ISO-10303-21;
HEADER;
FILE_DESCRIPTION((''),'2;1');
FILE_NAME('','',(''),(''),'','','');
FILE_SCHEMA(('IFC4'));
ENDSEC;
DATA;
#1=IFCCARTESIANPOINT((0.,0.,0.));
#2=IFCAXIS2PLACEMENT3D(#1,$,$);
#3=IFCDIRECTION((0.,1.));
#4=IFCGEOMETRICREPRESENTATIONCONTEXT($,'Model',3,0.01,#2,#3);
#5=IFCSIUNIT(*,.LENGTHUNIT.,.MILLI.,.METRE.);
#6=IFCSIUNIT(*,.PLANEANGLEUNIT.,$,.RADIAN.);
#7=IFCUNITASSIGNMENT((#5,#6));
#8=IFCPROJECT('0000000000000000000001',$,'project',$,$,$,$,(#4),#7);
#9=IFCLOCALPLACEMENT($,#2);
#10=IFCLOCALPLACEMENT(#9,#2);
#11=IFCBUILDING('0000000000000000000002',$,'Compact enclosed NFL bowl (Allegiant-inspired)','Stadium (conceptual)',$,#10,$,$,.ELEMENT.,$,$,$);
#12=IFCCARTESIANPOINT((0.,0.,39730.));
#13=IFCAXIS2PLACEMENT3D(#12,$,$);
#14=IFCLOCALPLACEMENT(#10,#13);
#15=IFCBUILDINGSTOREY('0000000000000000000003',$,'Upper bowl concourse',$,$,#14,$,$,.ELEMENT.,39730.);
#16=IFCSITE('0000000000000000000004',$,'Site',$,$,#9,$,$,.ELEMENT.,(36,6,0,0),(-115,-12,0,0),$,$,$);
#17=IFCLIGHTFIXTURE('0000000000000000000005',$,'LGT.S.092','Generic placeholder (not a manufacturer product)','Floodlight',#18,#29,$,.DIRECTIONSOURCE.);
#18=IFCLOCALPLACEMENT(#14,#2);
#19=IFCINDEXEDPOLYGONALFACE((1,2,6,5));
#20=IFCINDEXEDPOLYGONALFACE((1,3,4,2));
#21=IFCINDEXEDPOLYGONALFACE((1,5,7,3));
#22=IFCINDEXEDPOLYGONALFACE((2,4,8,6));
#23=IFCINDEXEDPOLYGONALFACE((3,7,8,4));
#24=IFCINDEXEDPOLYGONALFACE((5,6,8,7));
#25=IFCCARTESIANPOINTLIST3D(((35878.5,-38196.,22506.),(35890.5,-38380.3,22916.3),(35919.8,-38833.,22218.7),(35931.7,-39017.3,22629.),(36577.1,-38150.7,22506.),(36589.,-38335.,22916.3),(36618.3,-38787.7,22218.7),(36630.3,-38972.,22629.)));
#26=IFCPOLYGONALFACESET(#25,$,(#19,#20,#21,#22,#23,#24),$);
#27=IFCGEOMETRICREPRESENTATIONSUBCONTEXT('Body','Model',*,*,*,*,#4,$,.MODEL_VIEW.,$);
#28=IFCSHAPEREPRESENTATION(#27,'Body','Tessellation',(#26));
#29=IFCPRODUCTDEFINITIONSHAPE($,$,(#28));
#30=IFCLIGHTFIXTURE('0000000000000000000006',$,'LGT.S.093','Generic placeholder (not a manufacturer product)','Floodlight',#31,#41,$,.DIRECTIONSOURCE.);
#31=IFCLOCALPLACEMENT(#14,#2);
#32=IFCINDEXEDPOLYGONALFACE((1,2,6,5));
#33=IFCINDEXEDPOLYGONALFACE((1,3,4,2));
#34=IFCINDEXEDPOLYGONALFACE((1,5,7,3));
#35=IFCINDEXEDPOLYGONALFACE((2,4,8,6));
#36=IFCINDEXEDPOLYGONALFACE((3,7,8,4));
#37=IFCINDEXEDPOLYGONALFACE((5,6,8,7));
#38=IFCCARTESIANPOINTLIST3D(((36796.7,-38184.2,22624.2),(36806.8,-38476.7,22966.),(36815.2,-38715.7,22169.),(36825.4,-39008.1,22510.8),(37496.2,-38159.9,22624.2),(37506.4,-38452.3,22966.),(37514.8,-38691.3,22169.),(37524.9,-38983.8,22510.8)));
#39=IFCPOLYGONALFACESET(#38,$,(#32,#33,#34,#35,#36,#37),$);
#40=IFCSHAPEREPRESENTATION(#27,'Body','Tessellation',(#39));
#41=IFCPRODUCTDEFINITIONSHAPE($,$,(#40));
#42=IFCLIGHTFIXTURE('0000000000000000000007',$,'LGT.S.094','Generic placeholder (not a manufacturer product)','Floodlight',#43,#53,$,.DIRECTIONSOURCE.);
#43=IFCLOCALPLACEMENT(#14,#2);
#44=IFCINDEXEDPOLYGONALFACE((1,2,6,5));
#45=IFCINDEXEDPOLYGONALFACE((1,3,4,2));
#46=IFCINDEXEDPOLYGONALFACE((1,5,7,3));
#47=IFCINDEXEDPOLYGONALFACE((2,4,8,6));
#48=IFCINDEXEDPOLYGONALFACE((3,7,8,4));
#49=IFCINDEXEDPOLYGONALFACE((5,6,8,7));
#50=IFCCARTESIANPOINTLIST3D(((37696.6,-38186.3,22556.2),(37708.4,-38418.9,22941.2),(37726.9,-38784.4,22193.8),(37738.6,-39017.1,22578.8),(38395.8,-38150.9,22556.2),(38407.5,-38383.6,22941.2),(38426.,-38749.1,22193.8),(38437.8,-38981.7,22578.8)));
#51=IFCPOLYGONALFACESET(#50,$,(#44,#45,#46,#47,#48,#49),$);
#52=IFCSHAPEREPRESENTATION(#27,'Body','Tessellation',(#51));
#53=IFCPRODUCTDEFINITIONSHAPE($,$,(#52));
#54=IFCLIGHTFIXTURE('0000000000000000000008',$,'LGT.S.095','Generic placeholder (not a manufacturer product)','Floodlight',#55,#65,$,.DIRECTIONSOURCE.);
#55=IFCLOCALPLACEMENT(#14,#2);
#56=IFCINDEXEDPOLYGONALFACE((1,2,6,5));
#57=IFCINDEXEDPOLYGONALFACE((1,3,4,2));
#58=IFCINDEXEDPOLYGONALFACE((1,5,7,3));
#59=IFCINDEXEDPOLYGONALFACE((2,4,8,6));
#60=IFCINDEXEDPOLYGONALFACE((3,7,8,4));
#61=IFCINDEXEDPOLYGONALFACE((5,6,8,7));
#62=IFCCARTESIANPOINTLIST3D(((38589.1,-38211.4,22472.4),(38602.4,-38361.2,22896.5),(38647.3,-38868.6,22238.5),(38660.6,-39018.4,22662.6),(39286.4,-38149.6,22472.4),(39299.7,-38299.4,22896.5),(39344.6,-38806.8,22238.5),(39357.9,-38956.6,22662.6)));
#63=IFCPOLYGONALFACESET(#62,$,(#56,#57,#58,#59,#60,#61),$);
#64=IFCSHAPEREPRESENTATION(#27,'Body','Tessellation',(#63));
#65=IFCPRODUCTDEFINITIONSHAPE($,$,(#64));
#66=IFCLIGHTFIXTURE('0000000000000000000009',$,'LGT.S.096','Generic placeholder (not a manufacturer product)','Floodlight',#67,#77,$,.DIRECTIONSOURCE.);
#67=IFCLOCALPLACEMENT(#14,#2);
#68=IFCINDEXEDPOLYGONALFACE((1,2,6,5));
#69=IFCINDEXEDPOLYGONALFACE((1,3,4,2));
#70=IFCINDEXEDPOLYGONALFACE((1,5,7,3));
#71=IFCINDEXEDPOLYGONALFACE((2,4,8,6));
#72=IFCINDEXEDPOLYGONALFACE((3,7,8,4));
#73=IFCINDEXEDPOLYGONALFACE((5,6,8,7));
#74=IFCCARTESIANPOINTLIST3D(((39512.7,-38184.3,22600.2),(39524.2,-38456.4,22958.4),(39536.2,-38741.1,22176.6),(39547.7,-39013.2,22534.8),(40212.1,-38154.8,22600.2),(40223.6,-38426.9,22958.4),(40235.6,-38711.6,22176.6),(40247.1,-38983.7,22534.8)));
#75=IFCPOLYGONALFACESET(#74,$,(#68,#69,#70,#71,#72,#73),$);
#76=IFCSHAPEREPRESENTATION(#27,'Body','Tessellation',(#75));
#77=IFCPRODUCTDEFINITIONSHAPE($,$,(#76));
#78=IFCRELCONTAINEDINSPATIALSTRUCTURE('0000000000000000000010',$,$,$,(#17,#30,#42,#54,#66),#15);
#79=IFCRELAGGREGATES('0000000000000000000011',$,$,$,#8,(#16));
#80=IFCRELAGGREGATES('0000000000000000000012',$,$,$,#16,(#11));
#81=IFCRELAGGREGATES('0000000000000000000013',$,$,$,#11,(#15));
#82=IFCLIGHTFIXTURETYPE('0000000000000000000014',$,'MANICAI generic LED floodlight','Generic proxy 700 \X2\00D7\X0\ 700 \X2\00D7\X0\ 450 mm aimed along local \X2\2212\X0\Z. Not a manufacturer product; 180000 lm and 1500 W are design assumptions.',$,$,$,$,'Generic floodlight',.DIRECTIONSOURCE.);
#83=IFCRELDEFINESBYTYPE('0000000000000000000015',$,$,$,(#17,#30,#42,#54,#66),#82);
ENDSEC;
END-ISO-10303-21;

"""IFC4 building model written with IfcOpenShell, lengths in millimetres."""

from ifc_helpers import new_model, si_unit, direction, frame, origin, place, context, subcontext, project, spatial, rectangle, extrude, source, transform, mapped, type_object, type_shapes, element, save


model = new_model("IFC4")

# Units and contexts
model_context = context("Model", 3, precision=0.01, world=origin(), true_north=direction((0.0, 1.0)))
body_context = subcontext(model_context, "Body", "Model", "MODEL_VIEW")
ifc_project = project(units=[si_unit("LENGTHUNIT", "METRE", prefix="MILLI"), si_unit("PLANEANGLEUNIT", "RADIAN")], contexts=[model_context])

# Site, building, storey
site_placement = place(None, origin())
site = spatial("IfcSite", under=ifc_project, at=site_placement, Name="Site", CompositionType="ELEMENT", RefLatitude=(36, 6, 0, 0), RefLongitude=(-115, -12, 0, 0))
building_placement = place(site_placement, origin())
building = spatial("IfcBuilding", under=site, at=building_placement, Name="Compact enclosed NFL bowl (Allegiant-inspired)", Description="Stadium (conceptual)", CompositionType="ELEMENT")
storey_placement = place(building_placement, frame((0.0, 0.0, 39730.0)))
storey = spatial("IfcBuildingStorey", under=building, at=storey_placement, Name="Upper bowl concourse", CompositionType="ELEMENT", Elevation=39730.0)

# Light fixtures
light_fixture_type = type_object("IfcLightFixtureType", Name="MANICAI generic LED floodlight", Description="Generic proxy 700 × 700 × 450 mm aimed along local −Z. Not a manufacturer product; 180000 lm and 1500 W are design assumptions.", ElementType="Generic floodlight", PredefinedType="DIRECTIONSOURCE")
shared_shape = source(origin(), body_context, "Body", "SweptSolid", [
    extrude(rectangle(XDim=700.0, YDim=700.0), frame((0.0, 0.0, -225.0)), (0.0, 0.0, 1.0), 450.0),
])
type_shapes(light_fixture_type, [shared_shape])
for number, where, z_axis, x_axis, name in (
    (1, (36254.4, -38584.0, 22567.5), (0.026535, -0.409538, 0.911907), (0.997908, 0.064656, 0.0), "LGT.S.092"),
    (2, (37160.8, -38584.0, 22567.5), (0.022658, -0.649906, 0.759677), (0.999393, 0.034842, 0.0), "LGT.S.093"),
    (3, (38067.2, -38584.0, 22567.5), (0.02614, -0.517043, 0.85556), (0.998724, 0.050492, 0.0), "LGT.S.094"),
    (4, (38973.5, -38584.0, 22567.5), (0.029482, -0.332861, 0.942515), (0.9961, 0.088226, 0.0), "LGT.S.095"),
    (5, (39879.9, -38584.0, 22567.5), (0.02548, -0.604667, 0.796071), (0.999113, 0.042102, 0.0), "LGT.S.096"),
):
    element("IfcLightFixture", number, at=place(storey_placement, frame(where, z_axis=z_axis, x_axis=x_axis)), inside=storey, type_object=light_fixture_type, Name=name, Description="Generic placeholder (not a manufacturer product)", ObjectType="Floodlight", PredefinedType="DIRECTIONSOURCE", context=body_context, shape_type="MappedRepresentation", body=[
        mapped(shared_shape, transform((0.0, 0.0, 0.0))),
    ])

save(model, "model.ifc")
